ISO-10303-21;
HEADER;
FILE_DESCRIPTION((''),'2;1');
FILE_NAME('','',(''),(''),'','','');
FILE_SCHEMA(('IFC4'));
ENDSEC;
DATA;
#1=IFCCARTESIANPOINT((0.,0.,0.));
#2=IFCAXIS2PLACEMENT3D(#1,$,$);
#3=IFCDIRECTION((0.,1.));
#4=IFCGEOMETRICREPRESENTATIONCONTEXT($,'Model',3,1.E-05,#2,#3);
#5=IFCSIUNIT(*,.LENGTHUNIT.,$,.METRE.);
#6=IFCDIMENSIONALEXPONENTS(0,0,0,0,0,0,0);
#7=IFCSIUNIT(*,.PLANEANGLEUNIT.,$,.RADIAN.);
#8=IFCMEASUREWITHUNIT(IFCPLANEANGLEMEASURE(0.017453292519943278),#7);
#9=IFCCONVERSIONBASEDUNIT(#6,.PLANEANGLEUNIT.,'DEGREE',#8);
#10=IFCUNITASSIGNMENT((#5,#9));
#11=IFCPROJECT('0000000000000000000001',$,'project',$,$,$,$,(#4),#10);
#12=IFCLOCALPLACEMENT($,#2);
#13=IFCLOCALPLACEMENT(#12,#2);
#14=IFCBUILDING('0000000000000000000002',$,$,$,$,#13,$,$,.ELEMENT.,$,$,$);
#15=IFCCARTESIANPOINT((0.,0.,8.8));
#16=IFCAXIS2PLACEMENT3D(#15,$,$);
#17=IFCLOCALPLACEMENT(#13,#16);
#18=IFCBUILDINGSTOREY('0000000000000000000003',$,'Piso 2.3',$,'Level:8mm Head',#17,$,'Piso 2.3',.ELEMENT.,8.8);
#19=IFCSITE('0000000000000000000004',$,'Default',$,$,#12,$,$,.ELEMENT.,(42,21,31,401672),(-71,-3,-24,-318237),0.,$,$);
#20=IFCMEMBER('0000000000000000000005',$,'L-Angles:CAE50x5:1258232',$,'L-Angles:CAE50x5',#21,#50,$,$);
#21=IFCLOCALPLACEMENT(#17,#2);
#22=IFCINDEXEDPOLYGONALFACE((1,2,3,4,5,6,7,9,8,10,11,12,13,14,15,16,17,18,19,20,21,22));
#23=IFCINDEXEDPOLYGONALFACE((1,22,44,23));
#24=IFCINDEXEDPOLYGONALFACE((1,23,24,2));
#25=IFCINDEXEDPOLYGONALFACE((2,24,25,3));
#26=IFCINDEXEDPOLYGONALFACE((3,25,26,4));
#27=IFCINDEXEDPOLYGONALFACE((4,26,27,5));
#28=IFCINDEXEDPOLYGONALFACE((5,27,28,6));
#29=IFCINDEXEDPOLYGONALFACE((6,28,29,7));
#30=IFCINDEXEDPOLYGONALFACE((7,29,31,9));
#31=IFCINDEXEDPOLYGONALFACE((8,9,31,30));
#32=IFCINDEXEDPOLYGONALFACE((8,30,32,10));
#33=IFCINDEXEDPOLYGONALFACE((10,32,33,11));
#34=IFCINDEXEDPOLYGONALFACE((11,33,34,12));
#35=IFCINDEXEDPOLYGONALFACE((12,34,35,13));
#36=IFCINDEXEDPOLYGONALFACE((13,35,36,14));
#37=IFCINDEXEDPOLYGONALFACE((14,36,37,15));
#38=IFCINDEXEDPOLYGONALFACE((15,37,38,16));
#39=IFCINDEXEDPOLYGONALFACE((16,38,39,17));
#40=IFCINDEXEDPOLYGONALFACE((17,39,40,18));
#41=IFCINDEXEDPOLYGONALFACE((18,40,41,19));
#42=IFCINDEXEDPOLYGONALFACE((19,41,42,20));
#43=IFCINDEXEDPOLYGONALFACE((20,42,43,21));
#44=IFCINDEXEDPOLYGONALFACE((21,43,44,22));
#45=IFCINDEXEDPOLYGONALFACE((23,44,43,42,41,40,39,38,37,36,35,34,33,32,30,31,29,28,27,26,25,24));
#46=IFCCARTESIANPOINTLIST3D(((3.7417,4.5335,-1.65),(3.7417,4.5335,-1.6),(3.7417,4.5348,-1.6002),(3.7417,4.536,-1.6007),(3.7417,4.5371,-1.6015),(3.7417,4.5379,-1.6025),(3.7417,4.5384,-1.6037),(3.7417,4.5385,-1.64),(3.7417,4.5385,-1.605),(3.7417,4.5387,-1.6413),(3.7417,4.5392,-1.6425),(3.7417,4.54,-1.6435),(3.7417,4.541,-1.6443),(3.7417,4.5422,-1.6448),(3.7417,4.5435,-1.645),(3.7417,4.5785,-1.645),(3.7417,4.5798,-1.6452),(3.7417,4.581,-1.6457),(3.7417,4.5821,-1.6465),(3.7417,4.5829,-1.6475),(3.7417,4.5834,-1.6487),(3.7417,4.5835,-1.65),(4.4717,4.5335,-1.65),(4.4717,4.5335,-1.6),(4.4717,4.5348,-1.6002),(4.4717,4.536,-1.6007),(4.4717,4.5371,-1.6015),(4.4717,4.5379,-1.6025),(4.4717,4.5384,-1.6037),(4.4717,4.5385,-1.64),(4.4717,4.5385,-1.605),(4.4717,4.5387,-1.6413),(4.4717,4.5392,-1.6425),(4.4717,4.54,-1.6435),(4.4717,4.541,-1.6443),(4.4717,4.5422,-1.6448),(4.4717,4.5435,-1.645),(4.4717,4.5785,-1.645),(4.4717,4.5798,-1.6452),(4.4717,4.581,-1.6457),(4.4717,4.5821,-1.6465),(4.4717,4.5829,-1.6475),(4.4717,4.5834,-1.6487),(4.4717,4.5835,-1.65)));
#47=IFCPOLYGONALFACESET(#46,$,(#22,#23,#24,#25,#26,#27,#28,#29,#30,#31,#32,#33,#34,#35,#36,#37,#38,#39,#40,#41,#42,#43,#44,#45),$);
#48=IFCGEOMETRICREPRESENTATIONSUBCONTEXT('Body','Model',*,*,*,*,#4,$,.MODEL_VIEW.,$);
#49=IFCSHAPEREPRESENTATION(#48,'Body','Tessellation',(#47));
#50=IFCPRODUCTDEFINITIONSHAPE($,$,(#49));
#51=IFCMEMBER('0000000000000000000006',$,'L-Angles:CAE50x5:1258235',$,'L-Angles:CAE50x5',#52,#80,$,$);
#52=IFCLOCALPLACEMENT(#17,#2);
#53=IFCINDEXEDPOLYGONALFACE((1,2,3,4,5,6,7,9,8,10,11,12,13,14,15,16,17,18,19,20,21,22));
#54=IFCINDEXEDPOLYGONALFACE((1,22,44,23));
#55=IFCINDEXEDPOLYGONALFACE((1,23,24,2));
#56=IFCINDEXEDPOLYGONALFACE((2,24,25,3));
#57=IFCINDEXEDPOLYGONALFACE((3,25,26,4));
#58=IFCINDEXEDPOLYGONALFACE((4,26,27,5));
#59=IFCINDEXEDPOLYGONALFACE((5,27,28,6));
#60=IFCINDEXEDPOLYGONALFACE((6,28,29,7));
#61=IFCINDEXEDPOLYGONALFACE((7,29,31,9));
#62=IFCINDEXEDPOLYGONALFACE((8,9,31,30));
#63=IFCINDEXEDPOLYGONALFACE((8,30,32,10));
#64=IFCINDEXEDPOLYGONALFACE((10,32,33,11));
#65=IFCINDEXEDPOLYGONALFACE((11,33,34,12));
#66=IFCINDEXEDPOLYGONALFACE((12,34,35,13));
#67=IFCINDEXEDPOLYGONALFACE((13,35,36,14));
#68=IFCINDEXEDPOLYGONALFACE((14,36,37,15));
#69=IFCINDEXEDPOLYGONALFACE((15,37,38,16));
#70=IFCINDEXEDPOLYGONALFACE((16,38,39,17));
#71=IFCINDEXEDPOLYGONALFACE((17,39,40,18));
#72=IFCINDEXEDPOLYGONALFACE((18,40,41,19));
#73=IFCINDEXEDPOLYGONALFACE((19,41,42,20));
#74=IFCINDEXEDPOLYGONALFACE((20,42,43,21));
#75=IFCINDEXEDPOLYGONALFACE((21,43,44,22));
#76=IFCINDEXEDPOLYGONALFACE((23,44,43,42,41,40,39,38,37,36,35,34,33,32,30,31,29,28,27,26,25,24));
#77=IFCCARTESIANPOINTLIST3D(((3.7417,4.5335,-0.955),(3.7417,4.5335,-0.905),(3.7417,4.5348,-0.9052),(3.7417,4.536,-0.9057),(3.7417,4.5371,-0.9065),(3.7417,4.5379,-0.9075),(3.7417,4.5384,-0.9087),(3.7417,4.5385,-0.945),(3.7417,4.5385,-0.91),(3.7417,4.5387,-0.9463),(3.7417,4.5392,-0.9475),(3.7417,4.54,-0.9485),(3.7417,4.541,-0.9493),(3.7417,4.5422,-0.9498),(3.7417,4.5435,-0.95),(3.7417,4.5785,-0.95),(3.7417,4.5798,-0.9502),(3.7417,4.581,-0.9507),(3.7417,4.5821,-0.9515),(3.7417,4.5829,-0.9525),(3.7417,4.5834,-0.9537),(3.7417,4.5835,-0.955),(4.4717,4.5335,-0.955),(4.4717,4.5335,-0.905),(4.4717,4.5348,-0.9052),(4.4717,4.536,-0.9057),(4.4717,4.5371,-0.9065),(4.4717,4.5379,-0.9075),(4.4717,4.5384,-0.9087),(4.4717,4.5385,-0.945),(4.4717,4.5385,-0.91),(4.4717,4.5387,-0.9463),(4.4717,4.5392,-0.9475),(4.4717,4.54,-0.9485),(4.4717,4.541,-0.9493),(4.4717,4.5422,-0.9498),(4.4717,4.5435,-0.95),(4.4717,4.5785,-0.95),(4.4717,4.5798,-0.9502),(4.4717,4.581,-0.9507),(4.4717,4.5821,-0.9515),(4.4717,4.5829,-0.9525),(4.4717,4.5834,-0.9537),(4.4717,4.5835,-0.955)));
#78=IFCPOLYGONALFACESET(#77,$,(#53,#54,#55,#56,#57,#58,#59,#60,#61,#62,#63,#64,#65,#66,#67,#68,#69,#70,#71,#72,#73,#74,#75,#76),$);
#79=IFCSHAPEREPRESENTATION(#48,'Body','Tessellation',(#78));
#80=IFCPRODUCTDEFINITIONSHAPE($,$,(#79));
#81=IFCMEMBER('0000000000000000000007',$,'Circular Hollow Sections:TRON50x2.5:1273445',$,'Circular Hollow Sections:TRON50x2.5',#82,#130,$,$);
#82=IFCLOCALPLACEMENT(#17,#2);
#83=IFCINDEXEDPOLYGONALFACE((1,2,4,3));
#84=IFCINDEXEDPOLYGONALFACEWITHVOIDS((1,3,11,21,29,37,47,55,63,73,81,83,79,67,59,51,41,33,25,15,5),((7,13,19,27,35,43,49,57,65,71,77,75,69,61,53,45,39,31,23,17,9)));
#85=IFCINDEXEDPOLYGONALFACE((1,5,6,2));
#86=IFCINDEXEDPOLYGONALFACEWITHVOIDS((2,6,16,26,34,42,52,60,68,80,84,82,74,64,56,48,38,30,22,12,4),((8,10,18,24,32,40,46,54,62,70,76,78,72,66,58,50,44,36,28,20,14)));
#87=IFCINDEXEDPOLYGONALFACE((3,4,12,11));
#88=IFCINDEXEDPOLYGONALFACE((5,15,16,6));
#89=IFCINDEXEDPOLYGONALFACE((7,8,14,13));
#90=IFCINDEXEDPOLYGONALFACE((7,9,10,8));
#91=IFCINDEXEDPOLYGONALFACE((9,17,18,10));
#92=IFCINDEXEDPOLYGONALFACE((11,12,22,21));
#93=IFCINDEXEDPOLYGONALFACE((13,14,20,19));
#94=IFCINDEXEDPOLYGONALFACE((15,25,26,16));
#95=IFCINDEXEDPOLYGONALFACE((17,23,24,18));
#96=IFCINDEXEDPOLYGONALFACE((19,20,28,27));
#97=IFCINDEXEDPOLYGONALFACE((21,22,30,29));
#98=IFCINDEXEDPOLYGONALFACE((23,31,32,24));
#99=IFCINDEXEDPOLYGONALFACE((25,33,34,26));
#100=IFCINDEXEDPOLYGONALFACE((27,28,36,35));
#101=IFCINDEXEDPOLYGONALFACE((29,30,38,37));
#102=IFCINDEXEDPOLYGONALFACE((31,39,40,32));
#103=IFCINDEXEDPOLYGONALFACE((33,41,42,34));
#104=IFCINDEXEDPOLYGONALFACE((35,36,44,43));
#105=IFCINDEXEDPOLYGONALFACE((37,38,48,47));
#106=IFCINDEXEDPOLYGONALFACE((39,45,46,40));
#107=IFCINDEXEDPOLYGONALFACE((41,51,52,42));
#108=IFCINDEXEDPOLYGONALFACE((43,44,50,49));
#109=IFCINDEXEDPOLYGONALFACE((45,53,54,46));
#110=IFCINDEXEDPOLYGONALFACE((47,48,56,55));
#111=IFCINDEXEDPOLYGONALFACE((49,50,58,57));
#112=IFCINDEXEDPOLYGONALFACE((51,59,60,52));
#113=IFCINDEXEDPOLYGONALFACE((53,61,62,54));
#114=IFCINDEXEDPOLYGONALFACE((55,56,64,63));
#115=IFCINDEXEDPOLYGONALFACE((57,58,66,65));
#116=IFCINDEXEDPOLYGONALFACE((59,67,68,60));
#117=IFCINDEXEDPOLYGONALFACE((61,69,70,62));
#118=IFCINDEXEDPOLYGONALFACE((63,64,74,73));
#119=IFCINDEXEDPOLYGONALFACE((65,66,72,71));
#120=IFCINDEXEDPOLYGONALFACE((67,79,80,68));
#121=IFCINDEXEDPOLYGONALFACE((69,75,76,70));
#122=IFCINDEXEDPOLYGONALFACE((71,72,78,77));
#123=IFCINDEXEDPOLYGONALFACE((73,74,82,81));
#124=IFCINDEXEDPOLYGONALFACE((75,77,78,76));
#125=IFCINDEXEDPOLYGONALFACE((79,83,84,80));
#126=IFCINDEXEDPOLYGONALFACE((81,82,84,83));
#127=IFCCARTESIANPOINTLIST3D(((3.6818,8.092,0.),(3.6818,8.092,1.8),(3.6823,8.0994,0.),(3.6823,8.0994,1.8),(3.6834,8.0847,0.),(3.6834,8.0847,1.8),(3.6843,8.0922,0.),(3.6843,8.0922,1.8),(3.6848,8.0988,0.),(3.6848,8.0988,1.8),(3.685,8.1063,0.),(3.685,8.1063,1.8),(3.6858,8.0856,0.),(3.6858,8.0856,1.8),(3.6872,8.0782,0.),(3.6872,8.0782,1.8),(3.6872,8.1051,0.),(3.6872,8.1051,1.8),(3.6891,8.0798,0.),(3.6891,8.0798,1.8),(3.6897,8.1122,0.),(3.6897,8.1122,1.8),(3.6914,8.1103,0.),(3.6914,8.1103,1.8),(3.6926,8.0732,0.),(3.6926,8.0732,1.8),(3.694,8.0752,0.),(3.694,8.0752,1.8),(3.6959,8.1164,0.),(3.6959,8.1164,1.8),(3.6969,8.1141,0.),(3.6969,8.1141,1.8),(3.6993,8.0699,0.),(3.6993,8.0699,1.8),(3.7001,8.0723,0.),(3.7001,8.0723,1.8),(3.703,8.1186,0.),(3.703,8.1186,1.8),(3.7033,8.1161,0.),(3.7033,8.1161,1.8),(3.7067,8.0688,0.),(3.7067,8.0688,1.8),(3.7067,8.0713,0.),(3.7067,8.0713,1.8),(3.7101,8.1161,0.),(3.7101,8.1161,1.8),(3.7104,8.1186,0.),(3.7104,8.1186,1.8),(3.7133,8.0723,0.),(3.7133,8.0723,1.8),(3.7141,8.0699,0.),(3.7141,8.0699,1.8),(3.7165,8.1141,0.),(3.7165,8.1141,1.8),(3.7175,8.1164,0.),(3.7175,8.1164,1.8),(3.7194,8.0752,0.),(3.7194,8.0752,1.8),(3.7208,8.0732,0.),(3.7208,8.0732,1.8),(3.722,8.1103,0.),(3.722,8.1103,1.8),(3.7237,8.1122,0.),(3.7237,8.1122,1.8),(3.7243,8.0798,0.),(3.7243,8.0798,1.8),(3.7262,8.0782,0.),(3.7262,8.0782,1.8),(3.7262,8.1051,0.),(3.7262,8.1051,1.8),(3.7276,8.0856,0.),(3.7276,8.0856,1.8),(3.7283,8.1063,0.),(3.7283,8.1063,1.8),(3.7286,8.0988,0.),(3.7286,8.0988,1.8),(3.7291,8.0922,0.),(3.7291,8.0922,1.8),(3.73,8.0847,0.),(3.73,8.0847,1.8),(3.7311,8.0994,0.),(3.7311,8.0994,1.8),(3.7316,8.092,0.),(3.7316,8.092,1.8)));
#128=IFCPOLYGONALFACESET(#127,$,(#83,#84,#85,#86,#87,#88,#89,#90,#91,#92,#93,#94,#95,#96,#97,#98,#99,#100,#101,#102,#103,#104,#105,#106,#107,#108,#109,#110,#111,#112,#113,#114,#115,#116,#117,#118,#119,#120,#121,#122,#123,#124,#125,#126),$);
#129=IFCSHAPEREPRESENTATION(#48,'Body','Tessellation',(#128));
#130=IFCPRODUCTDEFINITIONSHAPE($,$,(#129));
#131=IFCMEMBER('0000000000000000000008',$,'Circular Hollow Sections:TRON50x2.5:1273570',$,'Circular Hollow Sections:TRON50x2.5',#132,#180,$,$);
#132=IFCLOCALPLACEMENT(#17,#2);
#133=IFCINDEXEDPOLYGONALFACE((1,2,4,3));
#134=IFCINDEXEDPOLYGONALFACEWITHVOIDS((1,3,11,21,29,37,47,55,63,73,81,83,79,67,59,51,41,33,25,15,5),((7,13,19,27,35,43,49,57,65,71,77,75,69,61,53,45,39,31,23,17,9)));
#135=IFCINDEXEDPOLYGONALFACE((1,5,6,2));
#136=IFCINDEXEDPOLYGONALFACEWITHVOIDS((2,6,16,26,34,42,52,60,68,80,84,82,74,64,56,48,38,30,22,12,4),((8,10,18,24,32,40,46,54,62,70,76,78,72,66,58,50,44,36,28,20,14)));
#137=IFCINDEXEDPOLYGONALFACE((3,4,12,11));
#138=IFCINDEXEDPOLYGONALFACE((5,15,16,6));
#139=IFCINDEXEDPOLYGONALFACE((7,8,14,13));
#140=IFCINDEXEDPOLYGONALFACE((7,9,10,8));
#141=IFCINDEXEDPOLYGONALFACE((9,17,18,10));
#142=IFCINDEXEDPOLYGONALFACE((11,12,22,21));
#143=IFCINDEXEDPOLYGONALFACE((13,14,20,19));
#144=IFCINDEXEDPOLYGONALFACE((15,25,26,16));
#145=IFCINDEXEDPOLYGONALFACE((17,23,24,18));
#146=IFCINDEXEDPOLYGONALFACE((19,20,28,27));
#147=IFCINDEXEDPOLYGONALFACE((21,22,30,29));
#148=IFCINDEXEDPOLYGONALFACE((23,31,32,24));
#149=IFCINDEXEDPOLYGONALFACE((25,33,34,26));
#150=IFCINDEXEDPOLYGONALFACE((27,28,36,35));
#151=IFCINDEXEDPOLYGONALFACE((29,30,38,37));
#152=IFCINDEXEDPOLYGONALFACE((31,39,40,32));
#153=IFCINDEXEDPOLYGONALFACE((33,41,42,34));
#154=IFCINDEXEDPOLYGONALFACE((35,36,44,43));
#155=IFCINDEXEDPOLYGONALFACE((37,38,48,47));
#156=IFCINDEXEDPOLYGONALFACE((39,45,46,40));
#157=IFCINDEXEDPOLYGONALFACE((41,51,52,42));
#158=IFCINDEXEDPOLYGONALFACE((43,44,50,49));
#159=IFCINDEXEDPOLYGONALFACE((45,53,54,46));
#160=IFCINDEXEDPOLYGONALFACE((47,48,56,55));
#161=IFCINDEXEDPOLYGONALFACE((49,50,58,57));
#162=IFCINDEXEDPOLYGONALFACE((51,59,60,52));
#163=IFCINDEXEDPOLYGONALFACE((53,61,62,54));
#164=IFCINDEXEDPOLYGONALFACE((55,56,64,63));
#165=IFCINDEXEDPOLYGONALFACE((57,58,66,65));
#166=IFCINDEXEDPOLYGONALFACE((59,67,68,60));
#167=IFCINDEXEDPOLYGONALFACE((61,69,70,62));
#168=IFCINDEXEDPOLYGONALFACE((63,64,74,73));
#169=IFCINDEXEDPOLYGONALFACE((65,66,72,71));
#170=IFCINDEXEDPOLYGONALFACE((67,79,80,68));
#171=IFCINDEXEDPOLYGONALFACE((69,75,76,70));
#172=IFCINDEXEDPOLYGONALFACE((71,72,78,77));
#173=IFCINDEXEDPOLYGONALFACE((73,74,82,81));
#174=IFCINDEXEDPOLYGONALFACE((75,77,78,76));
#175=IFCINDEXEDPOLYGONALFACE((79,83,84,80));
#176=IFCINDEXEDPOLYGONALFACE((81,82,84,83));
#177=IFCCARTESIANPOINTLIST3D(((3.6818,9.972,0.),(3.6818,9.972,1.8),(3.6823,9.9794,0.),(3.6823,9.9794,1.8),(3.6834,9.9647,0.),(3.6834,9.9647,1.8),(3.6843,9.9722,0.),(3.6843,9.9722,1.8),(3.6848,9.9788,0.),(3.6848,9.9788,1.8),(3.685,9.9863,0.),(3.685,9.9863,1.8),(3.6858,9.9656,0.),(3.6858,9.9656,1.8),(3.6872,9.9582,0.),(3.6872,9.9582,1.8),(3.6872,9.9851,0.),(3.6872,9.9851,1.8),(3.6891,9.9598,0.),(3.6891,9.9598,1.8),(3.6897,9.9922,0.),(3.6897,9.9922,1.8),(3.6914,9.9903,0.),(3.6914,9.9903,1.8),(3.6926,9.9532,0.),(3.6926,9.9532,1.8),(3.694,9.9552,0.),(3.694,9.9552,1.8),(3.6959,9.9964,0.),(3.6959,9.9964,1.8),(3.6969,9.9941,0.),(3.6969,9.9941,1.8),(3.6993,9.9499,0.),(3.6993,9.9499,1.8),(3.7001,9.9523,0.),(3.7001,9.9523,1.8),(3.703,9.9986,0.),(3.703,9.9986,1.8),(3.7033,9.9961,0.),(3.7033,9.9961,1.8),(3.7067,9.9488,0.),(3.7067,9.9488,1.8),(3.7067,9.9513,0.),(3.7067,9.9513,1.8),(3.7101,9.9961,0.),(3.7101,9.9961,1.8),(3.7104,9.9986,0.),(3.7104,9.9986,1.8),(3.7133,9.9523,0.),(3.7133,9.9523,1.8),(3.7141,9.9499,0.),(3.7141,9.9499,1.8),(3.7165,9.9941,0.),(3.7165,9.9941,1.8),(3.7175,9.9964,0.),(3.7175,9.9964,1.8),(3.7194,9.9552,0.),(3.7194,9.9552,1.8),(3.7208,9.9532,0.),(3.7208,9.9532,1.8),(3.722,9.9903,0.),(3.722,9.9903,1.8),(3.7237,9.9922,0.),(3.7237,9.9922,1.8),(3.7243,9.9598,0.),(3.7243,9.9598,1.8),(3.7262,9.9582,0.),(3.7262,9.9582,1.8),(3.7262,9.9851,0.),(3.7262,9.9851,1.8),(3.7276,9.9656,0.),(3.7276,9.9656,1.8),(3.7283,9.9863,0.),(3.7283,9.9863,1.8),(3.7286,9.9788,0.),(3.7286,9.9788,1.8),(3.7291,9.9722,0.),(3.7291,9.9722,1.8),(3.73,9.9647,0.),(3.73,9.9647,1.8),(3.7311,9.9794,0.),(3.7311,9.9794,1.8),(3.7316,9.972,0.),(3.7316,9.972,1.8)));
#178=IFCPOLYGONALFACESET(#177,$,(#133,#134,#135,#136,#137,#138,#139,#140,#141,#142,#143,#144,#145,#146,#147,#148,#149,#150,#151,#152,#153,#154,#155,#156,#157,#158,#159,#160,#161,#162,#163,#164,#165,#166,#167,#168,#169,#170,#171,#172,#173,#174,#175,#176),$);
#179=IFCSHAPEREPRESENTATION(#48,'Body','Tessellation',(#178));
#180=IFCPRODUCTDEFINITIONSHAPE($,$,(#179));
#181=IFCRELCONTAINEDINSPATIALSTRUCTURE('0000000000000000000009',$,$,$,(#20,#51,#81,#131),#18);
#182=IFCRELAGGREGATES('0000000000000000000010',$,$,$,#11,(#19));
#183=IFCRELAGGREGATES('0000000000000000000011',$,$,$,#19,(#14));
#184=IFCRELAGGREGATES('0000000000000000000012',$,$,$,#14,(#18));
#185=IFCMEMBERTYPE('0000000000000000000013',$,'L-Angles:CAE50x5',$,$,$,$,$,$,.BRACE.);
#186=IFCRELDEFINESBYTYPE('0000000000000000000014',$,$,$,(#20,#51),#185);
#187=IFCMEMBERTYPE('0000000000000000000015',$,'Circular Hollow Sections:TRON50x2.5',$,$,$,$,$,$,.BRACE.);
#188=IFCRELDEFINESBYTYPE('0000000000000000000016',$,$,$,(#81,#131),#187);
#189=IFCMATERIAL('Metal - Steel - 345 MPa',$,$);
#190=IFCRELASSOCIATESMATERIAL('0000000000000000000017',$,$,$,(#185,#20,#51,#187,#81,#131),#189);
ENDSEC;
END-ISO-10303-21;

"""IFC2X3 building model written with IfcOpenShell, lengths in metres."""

from ifc_helpers import new_model, entity, si_unit, converted_unit, direction, frame, frame_2d, origin, place, context, subcontext, project, spatial, polyline, circle_curve, parameter, trimmed, segment, composite_curve, hollow_circle, outline, extrude, source, transform, mapped, material, type_object, type_shapes, element, save


model = new_model("IFC2X3")

# Units and contexts
model_context = context("Model", 3, precision=1e-05, world=origin(), true_north=direction((0.0, 1.0)))
body_context = subcontext(model_context, "Body", "Model", "MODEL_VIEW")
ifc_project = project(units=[si_unit("LENGTHUNIT", "METRE"), converted_unit("PLANEANGLEUNIT", "DEGREE", entity("IfcPlaneAngleMeasure", 0.017453292519943278), si_unit("PLANEANGLEUNIT", "RADIAN"), dimensions=[0, 0, 0, 0, 0, 0, 0])], contexts=[model_context])

# Site, building, storey
site_placement = place(None, origin())
site = spatial("IfcSite", under=ifc_project, at=site_placement, Name="Default", CompositionType="ELEMENT", RefLatitude=(42, 21, 31, 401672), RefLongitude=(-71, -3, -24, -318237), RefElevation=0.0)
building_placement = place(site_placement, origin())
building = spatial("IfcBuilding", under=site, at=building_placement, CompositionType="ELEMENT")
storey_placement = place(building_placement, frame((0.0, 0.0, 8.8)))
storey = spatial("IfcBuildingStorey", under=building, at=storey_placement, Name="Piso 2.3", ObjectType="Level:8mm Head", LongName="Piso 2.3", CompositionType="ELEMENT", Elevation=8.8)

# Shared definitions
ifc_material_1 = material(Name="Metal - Steel - 345 MPa")

# Members
member_type_1 = type_object("IfcMemberType", Name="L-Angles:CAE50x5", PredefinedType="BRACE", material=ifc_material_1)
shared_shape_1 = source(origin(), body_context, "Body", "SweptSolid", [
    extrude(outline(composite_curve([segment(polyline([(-0.0164, -0.0164), (0.0336, -0.0164)]), True, "CONTINUOUS"), segment(trimmed(circle_curve(frame_2d((0.0286, -0.0164), x_axis=(1.0, 0.0)), 0.005), [parameter(0.0)], [parameter(90.0)], True, "PARAMETER"), True, "CONTINUOUS"), segment(polyline([(0.0286, -0.0114), (-0.0064, -0.0114)]), True, "CONTINUOUS"), segment(trimmed(circle_curve(frame_2d((-0.0064, -0.0064), x_axis=(1.0, 0.0)), 0.005), [parameter(180.0)], [parameter(270.0)], True, "PARAMETER"), False, "CONTINUOUS"), segment(polyline([(-0.0114, -0.0064), (-0.0114, 0.0286)]), True, "CONTINUOUS"), segment(trimmed(circle_curve(frame_2d((-0.0164, 0.0286), x_axis=(1.0, 0.0)), 0.005), [parameter(0.0)], [parameter(90.0)], True, "PARAMETER"), True, "CONTINUOUS"), segment(polyline([(-0.0164, 0.0336), (-0.0164, -0.0164)]), True, "CONTINUOUS")], self_intersect=False)), frame((-0.365, -0.0024, -0.0024), z_axis=(1.0, 0.0, 0.0), x_axis=(0.0, -1.0, 0.0)), (0.0, 0.0, 1.0), 0.73),
])
type_shapes(member_type_1, [shared_shape_1])
for number, where, z_axis, x_axis, name in (
    (1, (4.1067, 4.5475, -1.636), (0.0, -1.0, 0.0), (-1.0, 0.0, 0.0), "L-Angles:CAE50x5:1258232"),
    (2, (4.1067, 4.5475, -0.941), (0.0, -1.0, 0.0), (-1.0, 0.0, 0.0), "L-Angles:CAE50x5:1258235"),
):
    element("IfcMember", number, at=place(storey_placement, frame(where, z_axis=z_axis, x_axis=x_axis)), inside=storey, type_object=member_type_1, material=ifc_material_1, Name=name, ObjectType="L-Angles:CAE50x5", context=body_context, shape_type="MappedRepresentation", body=[
        mapped(shared_shape_1, transform((0.0, 0.0, 0.0), scale=1.0)),
    ])
member_type_2 = type_object("IfcMemberType", Name="Circular Hollow Sections:TRON50x2.5", PredefinedType="BRACE", material=ifc_material_1)
shared_shape_2 = source(origin(), body_context, "Body", "SweptSolid", [
    extrude(hollow_circle(Radius=0.025, WallThickness=0.0025, at=frame_2d((0.0, 0.0), x_axis=(1.0, 0.0))), frame((-0.9, 0.0, 0.0), z_axis=(1.0, 0.0, 0.0), x_axis=(0.0, 0.0, -1.0)), (0.0, 0.0, 1.0), 1.8),
])
type_shapes(member_type_2, [shared_shape_2])
for number, where, z_axis, x_axis, name in (
    (3, (3.7067, 8.0938, 0.9), (0.0, 1.0, 0.0), (0.0, 0.0, 1.0), "Circular Hollow Sections:TRON50x2.5:1273445"),
    (4, (3.7067, 9.9738, 0.9), (0.0, 1.0, 0.0), (0.0, 0.0, 1.0), "Circular Hollow Sections:TRON50x2.5:1273570"),
):
    element("IfcMember", number, at=place(storey_placement, frame(where, z_axis=z_axis, x_axis=x_axis)), inside=storey, type_object=member_type_2, material=ifc_material_1, Name=name, ObjectType="Circular Hollow Sections:TRON50x2.5", context=body_context, shape_type="MappedRepresentation", body=[
        mapped(shared_shape_2, transform((0.0, 0.0, 0.0), scale=1.0)),
    ])

save(model, "model.ifc")
